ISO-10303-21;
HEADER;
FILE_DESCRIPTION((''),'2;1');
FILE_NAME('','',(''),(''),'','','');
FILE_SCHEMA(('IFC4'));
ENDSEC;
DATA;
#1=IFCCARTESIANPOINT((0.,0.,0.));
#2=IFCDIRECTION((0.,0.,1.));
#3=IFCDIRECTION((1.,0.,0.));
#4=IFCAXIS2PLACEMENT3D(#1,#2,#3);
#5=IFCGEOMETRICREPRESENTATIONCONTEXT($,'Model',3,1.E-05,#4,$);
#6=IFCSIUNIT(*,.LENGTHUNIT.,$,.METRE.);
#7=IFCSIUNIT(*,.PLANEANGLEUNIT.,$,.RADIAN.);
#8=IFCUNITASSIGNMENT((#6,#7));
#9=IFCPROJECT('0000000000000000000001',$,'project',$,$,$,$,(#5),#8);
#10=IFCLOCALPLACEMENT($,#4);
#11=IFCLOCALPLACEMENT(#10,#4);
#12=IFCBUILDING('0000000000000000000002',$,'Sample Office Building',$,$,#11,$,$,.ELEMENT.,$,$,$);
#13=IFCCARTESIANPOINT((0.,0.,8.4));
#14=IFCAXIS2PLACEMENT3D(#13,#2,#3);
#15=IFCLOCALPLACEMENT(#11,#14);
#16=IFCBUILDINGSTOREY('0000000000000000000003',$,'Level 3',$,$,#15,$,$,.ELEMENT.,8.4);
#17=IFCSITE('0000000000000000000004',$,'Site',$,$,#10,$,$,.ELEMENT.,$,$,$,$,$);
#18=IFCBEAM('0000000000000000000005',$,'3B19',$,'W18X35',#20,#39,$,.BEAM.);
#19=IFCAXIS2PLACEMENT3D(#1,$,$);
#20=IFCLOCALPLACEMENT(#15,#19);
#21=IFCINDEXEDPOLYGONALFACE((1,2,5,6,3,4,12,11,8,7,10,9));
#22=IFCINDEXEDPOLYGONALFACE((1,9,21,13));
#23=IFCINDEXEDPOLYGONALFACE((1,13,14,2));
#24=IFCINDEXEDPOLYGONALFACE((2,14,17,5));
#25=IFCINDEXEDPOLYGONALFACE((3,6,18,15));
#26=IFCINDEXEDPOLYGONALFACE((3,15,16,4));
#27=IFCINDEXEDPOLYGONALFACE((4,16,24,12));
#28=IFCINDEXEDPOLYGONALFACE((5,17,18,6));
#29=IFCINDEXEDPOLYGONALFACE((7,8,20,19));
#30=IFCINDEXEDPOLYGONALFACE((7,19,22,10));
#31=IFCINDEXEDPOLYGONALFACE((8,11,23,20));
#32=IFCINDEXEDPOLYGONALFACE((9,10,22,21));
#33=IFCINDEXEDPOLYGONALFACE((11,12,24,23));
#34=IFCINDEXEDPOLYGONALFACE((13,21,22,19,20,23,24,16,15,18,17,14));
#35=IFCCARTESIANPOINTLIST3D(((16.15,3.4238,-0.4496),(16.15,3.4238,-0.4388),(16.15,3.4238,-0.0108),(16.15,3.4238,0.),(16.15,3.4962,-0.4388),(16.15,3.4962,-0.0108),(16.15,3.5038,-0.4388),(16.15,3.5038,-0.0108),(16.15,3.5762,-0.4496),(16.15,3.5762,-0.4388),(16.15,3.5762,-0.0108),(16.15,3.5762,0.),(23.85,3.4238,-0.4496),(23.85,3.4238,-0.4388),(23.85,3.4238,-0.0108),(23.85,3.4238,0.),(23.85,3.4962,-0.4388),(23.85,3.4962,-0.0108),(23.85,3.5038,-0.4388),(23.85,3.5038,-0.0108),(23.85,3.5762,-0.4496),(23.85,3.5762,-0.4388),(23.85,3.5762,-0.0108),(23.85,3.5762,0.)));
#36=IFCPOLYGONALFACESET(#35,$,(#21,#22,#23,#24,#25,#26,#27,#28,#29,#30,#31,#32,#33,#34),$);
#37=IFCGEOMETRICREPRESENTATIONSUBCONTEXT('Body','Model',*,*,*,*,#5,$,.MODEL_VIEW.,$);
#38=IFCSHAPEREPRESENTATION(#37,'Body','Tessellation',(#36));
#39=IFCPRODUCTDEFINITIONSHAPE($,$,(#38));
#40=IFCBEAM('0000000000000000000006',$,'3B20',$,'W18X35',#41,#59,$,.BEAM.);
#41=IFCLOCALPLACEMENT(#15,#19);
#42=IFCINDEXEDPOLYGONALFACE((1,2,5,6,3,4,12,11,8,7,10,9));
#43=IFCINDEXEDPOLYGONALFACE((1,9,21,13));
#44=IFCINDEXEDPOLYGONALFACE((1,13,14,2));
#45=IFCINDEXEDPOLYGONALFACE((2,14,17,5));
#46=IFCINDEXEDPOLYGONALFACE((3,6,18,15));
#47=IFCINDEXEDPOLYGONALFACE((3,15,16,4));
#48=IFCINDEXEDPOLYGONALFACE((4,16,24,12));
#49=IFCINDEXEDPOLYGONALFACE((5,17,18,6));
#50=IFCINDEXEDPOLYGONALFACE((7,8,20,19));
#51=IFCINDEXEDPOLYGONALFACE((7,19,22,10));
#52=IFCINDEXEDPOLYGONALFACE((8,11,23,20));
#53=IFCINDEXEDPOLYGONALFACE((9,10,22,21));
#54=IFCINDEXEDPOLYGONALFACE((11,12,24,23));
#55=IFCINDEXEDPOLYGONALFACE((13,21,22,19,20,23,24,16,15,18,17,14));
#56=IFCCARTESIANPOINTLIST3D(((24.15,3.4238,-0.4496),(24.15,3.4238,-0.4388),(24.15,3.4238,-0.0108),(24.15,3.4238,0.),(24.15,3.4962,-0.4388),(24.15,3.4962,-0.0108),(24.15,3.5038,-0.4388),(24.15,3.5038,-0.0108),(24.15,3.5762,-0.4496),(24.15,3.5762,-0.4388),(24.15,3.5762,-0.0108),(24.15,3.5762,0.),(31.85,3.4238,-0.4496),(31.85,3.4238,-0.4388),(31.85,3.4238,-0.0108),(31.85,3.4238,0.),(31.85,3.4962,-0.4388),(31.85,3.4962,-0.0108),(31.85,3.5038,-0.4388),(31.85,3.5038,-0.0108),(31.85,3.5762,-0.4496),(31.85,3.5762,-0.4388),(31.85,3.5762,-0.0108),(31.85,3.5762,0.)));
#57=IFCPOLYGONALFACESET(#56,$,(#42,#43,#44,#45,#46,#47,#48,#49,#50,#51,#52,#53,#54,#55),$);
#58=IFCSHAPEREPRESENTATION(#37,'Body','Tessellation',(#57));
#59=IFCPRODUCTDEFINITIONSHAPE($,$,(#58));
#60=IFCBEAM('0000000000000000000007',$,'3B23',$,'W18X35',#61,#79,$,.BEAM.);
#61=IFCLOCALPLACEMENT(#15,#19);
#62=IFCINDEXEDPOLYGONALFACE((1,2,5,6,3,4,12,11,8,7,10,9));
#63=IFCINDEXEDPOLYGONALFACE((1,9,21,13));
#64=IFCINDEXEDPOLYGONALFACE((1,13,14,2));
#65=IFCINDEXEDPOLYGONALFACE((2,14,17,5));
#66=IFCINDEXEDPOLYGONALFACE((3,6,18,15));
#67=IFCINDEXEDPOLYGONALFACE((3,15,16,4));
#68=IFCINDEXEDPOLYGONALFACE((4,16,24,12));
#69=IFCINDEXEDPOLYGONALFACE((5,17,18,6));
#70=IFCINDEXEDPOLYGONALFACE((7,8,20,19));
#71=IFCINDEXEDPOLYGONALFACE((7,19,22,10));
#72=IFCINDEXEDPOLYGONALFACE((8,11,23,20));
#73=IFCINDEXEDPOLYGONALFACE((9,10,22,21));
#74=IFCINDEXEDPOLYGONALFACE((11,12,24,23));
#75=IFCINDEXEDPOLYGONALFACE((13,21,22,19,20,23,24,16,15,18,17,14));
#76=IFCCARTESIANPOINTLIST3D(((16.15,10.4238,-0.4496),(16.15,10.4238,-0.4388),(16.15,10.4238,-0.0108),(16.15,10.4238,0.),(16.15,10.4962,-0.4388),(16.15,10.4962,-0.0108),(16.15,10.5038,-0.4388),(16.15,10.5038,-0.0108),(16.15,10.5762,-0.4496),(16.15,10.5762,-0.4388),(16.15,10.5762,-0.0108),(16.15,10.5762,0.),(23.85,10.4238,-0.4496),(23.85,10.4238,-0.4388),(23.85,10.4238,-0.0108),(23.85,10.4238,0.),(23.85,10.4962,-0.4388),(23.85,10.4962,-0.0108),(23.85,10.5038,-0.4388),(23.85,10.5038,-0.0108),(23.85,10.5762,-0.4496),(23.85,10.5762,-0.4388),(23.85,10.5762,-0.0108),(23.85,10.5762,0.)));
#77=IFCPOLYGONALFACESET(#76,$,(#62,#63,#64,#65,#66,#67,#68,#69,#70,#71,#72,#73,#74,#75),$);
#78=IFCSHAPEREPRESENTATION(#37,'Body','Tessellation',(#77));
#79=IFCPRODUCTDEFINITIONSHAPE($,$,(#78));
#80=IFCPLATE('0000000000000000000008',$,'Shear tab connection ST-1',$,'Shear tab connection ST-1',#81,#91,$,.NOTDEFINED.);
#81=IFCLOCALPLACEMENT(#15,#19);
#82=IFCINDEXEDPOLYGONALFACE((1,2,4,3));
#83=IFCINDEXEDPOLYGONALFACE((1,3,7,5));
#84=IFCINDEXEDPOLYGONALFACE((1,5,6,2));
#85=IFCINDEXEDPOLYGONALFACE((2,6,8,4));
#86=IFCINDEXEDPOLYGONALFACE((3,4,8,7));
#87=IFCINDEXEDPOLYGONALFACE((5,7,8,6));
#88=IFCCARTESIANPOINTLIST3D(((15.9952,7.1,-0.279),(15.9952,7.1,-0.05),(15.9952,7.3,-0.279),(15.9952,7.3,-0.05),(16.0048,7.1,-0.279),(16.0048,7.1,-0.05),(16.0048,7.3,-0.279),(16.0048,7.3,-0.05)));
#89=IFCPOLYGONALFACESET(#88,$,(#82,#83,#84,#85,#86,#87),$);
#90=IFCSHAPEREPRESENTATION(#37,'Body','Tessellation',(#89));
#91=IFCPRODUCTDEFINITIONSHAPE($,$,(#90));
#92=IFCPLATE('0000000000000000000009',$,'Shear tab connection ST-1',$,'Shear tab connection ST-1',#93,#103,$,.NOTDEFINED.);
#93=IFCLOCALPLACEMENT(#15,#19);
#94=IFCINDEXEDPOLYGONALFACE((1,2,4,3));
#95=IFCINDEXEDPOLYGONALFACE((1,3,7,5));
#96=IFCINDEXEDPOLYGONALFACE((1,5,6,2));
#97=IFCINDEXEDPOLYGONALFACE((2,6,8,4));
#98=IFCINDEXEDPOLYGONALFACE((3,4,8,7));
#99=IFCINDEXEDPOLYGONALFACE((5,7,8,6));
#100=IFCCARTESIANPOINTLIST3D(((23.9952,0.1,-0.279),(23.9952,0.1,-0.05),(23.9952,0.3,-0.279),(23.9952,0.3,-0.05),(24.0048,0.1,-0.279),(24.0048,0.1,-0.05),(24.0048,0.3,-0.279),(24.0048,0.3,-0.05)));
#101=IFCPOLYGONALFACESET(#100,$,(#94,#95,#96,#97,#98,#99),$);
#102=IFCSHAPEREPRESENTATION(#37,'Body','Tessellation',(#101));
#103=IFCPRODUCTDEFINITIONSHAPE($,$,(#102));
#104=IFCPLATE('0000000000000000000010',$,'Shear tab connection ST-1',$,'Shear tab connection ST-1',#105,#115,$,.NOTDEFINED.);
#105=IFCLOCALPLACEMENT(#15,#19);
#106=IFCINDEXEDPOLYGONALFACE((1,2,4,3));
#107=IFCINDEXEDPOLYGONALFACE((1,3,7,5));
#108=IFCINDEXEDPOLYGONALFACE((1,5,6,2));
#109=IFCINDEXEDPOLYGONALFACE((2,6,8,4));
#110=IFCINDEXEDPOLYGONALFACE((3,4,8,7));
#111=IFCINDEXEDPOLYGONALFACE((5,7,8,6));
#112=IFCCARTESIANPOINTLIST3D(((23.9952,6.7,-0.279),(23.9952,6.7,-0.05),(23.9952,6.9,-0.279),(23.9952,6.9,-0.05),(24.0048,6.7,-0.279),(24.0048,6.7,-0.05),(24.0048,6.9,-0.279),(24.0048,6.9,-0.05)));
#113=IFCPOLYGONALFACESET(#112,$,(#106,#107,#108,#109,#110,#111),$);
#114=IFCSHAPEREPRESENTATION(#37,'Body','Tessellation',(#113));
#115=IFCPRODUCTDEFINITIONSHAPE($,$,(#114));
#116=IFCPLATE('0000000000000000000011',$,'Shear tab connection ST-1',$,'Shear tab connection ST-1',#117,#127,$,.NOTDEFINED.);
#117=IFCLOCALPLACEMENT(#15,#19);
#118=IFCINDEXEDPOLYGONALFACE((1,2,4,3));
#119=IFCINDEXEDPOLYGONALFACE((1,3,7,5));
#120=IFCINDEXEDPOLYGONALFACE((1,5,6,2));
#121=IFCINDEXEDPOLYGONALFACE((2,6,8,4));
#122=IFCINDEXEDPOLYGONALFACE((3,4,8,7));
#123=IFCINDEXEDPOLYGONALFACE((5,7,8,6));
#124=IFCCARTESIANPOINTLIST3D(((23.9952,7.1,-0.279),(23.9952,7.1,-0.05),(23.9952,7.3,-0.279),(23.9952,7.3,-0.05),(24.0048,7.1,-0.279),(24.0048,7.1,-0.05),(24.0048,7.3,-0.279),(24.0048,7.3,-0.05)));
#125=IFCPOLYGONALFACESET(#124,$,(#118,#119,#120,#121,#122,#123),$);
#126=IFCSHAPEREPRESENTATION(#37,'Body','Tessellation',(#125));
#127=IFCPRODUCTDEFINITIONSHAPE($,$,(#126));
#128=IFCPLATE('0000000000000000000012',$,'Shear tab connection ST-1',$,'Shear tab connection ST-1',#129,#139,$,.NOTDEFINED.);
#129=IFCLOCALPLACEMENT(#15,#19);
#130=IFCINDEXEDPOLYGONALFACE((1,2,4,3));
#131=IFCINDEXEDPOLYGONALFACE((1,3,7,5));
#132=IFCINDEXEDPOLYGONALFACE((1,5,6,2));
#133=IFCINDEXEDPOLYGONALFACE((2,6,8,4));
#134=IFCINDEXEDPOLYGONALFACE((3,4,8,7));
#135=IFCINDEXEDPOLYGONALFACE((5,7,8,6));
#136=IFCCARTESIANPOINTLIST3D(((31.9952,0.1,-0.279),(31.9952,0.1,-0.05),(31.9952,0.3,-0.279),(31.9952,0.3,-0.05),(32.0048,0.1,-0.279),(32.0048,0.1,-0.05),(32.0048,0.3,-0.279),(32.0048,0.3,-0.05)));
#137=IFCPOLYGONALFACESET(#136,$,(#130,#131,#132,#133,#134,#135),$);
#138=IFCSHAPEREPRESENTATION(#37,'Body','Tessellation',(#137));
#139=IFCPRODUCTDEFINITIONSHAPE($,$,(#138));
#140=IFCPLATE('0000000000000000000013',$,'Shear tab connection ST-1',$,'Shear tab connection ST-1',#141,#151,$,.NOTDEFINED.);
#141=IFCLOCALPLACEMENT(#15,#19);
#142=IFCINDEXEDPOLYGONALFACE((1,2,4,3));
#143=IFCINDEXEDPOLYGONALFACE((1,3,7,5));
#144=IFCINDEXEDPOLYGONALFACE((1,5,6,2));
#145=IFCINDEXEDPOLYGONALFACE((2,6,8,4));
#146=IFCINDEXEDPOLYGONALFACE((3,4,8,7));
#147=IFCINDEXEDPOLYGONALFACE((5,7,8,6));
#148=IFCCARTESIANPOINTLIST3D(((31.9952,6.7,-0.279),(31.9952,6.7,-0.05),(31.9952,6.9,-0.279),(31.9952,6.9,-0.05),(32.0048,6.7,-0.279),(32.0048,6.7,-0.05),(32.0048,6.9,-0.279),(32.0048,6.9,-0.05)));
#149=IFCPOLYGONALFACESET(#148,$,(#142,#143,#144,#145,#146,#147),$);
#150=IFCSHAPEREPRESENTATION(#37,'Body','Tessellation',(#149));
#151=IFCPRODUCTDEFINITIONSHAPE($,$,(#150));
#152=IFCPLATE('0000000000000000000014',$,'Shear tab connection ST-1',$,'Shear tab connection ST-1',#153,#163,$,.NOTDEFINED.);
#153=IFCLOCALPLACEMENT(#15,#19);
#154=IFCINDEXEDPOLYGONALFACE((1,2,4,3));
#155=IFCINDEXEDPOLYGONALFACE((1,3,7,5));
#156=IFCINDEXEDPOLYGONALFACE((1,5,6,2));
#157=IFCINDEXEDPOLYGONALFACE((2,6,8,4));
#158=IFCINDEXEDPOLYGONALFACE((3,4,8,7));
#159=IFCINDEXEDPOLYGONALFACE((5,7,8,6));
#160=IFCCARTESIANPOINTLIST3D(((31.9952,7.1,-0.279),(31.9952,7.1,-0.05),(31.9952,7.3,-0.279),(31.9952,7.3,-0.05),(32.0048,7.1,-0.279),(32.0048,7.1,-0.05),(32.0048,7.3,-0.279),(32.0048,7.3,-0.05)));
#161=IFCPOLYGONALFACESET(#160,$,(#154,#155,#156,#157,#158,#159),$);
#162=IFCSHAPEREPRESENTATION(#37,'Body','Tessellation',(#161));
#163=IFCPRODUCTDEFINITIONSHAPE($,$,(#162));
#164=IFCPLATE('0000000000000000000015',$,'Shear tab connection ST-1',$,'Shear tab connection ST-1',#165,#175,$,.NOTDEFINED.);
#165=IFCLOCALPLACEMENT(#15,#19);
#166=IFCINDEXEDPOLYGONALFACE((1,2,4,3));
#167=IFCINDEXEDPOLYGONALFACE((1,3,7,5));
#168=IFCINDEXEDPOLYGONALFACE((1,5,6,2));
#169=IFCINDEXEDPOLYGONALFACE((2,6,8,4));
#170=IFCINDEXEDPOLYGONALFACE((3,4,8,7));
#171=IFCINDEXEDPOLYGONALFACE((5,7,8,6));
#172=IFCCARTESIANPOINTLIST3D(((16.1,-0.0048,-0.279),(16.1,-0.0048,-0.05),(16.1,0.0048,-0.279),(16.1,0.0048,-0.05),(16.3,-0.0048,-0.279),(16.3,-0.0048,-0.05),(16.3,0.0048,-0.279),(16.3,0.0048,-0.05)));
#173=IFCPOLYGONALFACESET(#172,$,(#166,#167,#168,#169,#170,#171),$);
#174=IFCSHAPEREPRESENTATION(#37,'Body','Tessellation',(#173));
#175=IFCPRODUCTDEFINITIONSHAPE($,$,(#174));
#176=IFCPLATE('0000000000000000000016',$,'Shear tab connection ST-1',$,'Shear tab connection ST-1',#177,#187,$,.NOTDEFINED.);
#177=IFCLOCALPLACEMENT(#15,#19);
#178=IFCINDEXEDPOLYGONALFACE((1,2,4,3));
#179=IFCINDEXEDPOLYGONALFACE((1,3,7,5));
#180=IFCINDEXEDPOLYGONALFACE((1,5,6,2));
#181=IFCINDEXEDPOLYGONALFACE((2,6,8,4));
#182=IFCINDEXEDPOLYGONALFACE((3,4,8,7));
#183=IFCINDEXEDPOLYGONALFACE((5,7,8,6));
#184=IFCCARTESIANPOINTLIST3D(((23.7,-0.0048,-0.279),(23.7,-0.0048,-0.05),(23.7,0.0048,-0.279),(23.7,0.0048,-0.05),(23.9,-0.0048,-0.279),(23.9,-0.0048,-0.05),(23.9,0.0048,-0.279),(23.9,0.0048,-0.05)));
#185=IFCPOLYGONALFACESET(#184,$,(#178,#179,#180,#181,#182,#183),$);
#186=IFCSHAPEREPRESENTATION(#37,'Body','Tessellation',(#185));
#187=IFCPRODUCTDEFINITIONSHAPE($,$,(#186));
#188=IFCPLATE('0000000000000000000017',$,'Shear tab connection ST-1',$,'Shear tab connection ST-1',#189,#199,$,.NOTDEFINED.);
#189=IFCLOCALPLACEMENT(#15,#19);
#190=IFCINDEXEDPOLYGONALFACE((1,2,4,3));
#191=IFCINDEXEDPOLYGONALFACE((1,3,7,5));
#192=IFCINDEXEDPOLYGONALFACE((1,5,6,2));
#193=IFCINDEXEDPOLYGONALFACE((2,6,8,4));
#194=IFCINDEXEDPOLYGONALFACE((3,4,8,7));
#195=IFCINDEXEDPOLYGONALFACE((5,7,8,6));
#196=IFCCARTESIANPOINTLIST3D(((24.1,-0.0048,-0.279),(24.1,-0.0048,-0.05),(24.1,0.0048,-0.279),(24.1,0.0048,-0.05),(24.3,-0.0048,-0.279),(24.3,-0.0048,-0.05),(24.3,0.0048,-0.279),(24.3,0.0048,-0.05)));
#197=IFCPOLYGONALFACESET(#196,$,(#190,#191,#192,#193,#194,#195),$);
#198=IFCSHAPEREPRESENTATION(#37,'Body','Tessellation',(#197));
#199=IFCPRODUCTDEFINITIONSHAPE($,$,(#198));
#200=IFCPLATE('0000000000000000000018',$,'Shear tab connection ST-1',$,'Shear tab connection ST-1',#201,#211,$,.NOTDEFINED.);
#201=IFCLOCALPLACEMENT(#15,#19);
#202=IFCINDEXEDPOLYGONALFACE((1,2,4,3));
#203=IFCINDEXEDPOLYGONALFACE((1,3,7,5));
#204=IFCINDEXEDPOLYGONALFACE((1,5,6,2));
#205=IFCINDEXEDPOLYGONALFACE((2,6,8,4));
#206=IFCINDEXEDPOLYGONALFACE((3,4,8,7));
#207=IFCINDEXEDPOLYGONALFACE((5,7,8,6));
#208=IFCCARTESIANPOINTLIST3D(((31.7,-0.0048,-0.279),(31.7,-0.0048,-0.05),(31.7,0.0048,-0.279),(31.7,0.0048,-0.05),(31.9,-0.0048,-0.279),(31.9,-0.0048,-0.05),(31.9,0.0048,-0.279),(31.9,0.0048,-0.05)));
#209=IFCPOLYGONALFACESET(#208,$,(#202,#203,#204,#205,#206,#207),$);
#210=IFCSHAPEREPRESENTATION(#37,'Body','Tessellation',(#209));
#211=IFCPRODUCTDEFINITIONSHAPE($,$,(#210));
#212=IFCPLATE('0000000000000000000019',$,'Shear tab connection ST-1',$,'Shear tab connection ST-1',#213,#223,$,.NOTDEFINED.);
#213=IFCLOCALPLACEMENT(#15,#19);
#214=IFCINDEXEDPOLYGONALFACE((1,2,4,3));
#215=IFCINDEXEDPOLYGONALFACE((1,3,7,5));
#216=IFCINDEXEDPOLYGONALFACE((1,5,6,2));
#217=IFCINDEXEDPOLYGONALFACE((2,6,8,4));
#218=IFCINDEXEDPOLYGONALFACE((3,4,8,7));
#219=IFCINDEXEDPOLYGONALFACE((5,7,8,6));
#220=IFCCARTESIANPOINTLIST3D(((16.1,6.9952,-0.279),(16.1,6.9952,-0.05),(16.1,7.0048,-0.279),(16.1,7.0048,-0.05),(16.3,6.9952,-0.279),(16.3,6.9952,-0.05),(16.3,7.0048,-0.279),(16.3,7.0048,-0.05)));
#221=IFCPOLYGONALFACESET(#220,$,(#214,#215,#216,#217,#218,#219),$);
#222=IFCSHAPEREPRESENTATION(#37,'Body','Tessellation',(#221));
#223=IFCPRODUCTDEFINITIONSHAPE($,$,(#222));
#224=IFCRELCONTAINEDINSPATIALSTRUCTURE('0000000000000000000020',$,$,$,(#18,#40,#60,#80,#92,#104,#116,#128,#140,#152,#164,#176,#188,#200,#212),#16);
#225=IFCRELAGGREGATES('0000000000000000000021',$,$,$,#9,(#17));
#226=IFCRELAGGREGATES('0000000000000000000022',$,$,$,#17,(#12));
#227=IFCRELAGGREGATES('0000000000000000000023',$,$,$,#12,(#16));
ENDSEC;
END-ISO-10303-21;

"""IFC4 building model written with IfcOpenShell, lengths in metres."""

from ifc_helpers import new_model, si_unit, frame, origin_with_axes, place, context, subcontext, project, spatial, rectangle, i_section, extrude, element, save


model = new_model("IFC4")

# Units and contexts
model_context = context("Model", 3, precision=1e-05, world=origin_with_axes())
body_context = subcontext(model_context, "Body", "Model", "MODEL_VIEW")
ifc_project = project(units=[si_unit("LENGTHUNIT", "METRE"), si_unit("PLANEANGLEUNIT", "RADIAN")], contexts=[model_context])

# Site, building, storey
site_placement = place(None, origin_with_axes())
site = spatial("IfcSite", under=ifc_project, at=site_placement, Name="Site", CompositionType="ELEMENT")
building_placement = place(site_placement, origin_with_axes())
building = spatial("IfcBuilding", under=site, at=building_placement, Name="Sample Office Building", CompositionType="ELEMENT")
storey_placement = place(building_placement, frame((0.0, 0.0, 8.4), z_axis=(0.0, 0.0, 1.0), x_axis=(1.0, 0.0, 0.0)))
storey = spatial("IfcBuildingStorey", under=building, at=storey_placement, Name="Level 3", CompositionType="ELEMENT", Elevation=8.4)

# Beams
for number, where, z_axis, x_axis, name in (
    (1, (16.15, 3.5, 8.1752), (1.0, 0.0, 0.0), (0.0, 1.0, 0.0), "3B19"),
    (2, (24.15, 3.5, 8.1752), (1.0, 0.0, 0.0), (0.0, 1.0, 0.0), "3B20"),
    (3, (16.15, 10.5, 8.1752), (1.0, 0.0, 0.0), (0.0, 1.0, 0.0), "3B23"),
):
    element("IfcBeam", number, at=place(None, frame(where, z_axis=z_axis, x_axis=x_axis)), inside=storey, Name=name, ObjectType="W18X35", PredefinedType="BEAM", context=body_context, shape_type="SweptSolid", body=[
        extrude(i_section(OverallWidth=0.1524, OverallDepth=0.4496, WebThickness=0.0076, FlangeThickness=0.0108), None, (0.0, 0.0, 1.0), 7.7),
    ])

# Plates
plate_1_placement = place(None, frame((16.0, 7.2, 8.121), z_axis=(0.0, 0.0, 1.0), x_axis=(1.0, 0.0, 0.0)))
element("IfcPlate", 4, at=plate_1_placement, inside=storey, Name="Shear tab connection ST-1", ObjectType="Shear tab connection ST-1", PredefinedType="NOTDEFINED", context=body_context, shape_type="SweptSolid", body=[
    extrude(rectangle(XDim=0.0095, YDim=0.2), None, (0.0, 0.0, 1.0), 0.229),
])
plate_2_placement = place(None, frame((24.0, 0.2, 8.121), z_axis=(0.0, 0.0, 1.0), x_axis=(1.0, 0.0, 0.0)))
element("IfcPlate", 5, at=plate_2_placement, inside=storey, Name="Shear tab connection ST-1", ObjectType="Shear tab connection ST-1", PredefinedType="NOTDEFINED", context=body_context, shape_type="SweptSolid", body=[
    extrude(rectangle(XDim=0.0095, YDim=0.2), None, (0.0, 0.0, 1.0), 0.229),
])
for number, where, z_axis, x_axis, name in (
    (6, (24.0, 6.8, 8.121), (0.0, 0.0, 1.0), (1.0, 0.0, 0.0), "Shear tab connection ST-1"),
    (7, (24.0, 7.2, 8.121), (0.0, 0.0, 1.0), (1.0, 0.0, 0.0), "Shear tab connection ST-1"),
):
    element("IfcPlate", number, at=place(None, frame(where, z_axis=z_axis, x_axis=x_axis)), inside=storey, Name=name, ObjectType="Shear tab connection ST-1", PredefinedType="NOTDEFINED", context=body_context, shape_type="SweptSolid", body=[
        extrude(rectangle(XDim=0.0095, YDim=0.2), None, (0.0, 0.0, 1.0), 0.229),
    ])
plate_3_placement = place(None, frame((32.0, 0.2, 8.121), z_axis=(0.0, 0.0, 1.0), x_axis=(1.0, 0.0, 0.0)))
element("IfcPlate", 8, at=plate_3_placement, inside=storey, Name="Shear tab connection ST-1", ObjectType="Shear tab connection ST-1", PredefinedType="NOTDEFINED", context=body_context, shape_type="SweptSolid", body=[
    extrude(rectangle(XDim=0.0095, YDim=0.2), None, (0.0, 0.0, 1.0), 0.229),
])
for number, where, z_axis, x_axis, name in (
    (9, (32.0, 6.8, 8.121), (0.0, 0.0, 1.0), (1.0, 0.0, 0.0), "Shear tab connection ST-1"),
    (10, (32.0, 7.2, 8.121), (0.0, 0.0, 1.0), (1.0, 0.0, 0.0), "Shear tab connection ST-1"),
):
    element("IfcPlate", number, at=place(None, frame(where, z_axis=z_axis, x_axis=x_axis)), inside=storey, Name=name, ObjectType="Shear tab connection ST-1", PredefinedType="NOTDEFINED", context=body_context, shape_type="SweptSolid", body=[
        extrude(rectangle(XDim=0.0095, YDim=0.2), None, (0.0, 0.0, 1.0), 0.229),
    ])
for number, where, z_axis, x_axis, name in (
    (11, (16.2, 0.0, 8.121), (0.0, 0.0, 1.0), (1.0, 0.0, 0.0), "Shear tab connection ST-1"),
    (12, (23.8, 0.0, 8.121), (0.0, 0.0, 1.0), (1.0, 0.0, 0.0), "Shear tab connection ST-1"),
    (13, (24.2, 0.0, 8.121), (0.0, 0.0, 1.0), (1.0, 0.0, 0.0), "Shear tab connection ST-1"),
    (14, (31.8, 0.0, 8.121), (0.0, 0.0, 1.0), (1.0, 0.0, 0.0), "Shear tab connection ST-1"),
):
    element("IfcPlate", number, at=place(None, frame(where, z_axis=z_axis, x_axis=x_axis)), inside=storey, Name=name, ObjectType="Shear tab connection ST-1", PredefinedType="NOTDEFINED", context=body_context, shape_type="SweptSolid", body=[
        extrude(rectangle(XDim=0.2, YDim=0.0095), None, (0.0, 0.0, 1.0), 0.229),
    ])
for number, where, z_axis, x_axis, name in (
    (15, (16.2, 7.0, 8.121), (0.0, 0.0, 1.0), (1.0, 0.0, 0.0), "Shear tab connection ST-1"),
):
    element("IfcPlate", number, at=place(None, frame(where, z_axis=z_axis, x_axis=x_axis)), inside=storey, Name=name, ObjectType="Shear tab connection ST-1", PredefinedType="NOTDEFINED", context=body_context, shape_type="SweptSolid", body=[
        extrude(rectangle(XDim=0.2, YDim=0.0095), None, (0.0, 0.0, 1.0), 0.229),
    ])

save(model, "model.ifc")
